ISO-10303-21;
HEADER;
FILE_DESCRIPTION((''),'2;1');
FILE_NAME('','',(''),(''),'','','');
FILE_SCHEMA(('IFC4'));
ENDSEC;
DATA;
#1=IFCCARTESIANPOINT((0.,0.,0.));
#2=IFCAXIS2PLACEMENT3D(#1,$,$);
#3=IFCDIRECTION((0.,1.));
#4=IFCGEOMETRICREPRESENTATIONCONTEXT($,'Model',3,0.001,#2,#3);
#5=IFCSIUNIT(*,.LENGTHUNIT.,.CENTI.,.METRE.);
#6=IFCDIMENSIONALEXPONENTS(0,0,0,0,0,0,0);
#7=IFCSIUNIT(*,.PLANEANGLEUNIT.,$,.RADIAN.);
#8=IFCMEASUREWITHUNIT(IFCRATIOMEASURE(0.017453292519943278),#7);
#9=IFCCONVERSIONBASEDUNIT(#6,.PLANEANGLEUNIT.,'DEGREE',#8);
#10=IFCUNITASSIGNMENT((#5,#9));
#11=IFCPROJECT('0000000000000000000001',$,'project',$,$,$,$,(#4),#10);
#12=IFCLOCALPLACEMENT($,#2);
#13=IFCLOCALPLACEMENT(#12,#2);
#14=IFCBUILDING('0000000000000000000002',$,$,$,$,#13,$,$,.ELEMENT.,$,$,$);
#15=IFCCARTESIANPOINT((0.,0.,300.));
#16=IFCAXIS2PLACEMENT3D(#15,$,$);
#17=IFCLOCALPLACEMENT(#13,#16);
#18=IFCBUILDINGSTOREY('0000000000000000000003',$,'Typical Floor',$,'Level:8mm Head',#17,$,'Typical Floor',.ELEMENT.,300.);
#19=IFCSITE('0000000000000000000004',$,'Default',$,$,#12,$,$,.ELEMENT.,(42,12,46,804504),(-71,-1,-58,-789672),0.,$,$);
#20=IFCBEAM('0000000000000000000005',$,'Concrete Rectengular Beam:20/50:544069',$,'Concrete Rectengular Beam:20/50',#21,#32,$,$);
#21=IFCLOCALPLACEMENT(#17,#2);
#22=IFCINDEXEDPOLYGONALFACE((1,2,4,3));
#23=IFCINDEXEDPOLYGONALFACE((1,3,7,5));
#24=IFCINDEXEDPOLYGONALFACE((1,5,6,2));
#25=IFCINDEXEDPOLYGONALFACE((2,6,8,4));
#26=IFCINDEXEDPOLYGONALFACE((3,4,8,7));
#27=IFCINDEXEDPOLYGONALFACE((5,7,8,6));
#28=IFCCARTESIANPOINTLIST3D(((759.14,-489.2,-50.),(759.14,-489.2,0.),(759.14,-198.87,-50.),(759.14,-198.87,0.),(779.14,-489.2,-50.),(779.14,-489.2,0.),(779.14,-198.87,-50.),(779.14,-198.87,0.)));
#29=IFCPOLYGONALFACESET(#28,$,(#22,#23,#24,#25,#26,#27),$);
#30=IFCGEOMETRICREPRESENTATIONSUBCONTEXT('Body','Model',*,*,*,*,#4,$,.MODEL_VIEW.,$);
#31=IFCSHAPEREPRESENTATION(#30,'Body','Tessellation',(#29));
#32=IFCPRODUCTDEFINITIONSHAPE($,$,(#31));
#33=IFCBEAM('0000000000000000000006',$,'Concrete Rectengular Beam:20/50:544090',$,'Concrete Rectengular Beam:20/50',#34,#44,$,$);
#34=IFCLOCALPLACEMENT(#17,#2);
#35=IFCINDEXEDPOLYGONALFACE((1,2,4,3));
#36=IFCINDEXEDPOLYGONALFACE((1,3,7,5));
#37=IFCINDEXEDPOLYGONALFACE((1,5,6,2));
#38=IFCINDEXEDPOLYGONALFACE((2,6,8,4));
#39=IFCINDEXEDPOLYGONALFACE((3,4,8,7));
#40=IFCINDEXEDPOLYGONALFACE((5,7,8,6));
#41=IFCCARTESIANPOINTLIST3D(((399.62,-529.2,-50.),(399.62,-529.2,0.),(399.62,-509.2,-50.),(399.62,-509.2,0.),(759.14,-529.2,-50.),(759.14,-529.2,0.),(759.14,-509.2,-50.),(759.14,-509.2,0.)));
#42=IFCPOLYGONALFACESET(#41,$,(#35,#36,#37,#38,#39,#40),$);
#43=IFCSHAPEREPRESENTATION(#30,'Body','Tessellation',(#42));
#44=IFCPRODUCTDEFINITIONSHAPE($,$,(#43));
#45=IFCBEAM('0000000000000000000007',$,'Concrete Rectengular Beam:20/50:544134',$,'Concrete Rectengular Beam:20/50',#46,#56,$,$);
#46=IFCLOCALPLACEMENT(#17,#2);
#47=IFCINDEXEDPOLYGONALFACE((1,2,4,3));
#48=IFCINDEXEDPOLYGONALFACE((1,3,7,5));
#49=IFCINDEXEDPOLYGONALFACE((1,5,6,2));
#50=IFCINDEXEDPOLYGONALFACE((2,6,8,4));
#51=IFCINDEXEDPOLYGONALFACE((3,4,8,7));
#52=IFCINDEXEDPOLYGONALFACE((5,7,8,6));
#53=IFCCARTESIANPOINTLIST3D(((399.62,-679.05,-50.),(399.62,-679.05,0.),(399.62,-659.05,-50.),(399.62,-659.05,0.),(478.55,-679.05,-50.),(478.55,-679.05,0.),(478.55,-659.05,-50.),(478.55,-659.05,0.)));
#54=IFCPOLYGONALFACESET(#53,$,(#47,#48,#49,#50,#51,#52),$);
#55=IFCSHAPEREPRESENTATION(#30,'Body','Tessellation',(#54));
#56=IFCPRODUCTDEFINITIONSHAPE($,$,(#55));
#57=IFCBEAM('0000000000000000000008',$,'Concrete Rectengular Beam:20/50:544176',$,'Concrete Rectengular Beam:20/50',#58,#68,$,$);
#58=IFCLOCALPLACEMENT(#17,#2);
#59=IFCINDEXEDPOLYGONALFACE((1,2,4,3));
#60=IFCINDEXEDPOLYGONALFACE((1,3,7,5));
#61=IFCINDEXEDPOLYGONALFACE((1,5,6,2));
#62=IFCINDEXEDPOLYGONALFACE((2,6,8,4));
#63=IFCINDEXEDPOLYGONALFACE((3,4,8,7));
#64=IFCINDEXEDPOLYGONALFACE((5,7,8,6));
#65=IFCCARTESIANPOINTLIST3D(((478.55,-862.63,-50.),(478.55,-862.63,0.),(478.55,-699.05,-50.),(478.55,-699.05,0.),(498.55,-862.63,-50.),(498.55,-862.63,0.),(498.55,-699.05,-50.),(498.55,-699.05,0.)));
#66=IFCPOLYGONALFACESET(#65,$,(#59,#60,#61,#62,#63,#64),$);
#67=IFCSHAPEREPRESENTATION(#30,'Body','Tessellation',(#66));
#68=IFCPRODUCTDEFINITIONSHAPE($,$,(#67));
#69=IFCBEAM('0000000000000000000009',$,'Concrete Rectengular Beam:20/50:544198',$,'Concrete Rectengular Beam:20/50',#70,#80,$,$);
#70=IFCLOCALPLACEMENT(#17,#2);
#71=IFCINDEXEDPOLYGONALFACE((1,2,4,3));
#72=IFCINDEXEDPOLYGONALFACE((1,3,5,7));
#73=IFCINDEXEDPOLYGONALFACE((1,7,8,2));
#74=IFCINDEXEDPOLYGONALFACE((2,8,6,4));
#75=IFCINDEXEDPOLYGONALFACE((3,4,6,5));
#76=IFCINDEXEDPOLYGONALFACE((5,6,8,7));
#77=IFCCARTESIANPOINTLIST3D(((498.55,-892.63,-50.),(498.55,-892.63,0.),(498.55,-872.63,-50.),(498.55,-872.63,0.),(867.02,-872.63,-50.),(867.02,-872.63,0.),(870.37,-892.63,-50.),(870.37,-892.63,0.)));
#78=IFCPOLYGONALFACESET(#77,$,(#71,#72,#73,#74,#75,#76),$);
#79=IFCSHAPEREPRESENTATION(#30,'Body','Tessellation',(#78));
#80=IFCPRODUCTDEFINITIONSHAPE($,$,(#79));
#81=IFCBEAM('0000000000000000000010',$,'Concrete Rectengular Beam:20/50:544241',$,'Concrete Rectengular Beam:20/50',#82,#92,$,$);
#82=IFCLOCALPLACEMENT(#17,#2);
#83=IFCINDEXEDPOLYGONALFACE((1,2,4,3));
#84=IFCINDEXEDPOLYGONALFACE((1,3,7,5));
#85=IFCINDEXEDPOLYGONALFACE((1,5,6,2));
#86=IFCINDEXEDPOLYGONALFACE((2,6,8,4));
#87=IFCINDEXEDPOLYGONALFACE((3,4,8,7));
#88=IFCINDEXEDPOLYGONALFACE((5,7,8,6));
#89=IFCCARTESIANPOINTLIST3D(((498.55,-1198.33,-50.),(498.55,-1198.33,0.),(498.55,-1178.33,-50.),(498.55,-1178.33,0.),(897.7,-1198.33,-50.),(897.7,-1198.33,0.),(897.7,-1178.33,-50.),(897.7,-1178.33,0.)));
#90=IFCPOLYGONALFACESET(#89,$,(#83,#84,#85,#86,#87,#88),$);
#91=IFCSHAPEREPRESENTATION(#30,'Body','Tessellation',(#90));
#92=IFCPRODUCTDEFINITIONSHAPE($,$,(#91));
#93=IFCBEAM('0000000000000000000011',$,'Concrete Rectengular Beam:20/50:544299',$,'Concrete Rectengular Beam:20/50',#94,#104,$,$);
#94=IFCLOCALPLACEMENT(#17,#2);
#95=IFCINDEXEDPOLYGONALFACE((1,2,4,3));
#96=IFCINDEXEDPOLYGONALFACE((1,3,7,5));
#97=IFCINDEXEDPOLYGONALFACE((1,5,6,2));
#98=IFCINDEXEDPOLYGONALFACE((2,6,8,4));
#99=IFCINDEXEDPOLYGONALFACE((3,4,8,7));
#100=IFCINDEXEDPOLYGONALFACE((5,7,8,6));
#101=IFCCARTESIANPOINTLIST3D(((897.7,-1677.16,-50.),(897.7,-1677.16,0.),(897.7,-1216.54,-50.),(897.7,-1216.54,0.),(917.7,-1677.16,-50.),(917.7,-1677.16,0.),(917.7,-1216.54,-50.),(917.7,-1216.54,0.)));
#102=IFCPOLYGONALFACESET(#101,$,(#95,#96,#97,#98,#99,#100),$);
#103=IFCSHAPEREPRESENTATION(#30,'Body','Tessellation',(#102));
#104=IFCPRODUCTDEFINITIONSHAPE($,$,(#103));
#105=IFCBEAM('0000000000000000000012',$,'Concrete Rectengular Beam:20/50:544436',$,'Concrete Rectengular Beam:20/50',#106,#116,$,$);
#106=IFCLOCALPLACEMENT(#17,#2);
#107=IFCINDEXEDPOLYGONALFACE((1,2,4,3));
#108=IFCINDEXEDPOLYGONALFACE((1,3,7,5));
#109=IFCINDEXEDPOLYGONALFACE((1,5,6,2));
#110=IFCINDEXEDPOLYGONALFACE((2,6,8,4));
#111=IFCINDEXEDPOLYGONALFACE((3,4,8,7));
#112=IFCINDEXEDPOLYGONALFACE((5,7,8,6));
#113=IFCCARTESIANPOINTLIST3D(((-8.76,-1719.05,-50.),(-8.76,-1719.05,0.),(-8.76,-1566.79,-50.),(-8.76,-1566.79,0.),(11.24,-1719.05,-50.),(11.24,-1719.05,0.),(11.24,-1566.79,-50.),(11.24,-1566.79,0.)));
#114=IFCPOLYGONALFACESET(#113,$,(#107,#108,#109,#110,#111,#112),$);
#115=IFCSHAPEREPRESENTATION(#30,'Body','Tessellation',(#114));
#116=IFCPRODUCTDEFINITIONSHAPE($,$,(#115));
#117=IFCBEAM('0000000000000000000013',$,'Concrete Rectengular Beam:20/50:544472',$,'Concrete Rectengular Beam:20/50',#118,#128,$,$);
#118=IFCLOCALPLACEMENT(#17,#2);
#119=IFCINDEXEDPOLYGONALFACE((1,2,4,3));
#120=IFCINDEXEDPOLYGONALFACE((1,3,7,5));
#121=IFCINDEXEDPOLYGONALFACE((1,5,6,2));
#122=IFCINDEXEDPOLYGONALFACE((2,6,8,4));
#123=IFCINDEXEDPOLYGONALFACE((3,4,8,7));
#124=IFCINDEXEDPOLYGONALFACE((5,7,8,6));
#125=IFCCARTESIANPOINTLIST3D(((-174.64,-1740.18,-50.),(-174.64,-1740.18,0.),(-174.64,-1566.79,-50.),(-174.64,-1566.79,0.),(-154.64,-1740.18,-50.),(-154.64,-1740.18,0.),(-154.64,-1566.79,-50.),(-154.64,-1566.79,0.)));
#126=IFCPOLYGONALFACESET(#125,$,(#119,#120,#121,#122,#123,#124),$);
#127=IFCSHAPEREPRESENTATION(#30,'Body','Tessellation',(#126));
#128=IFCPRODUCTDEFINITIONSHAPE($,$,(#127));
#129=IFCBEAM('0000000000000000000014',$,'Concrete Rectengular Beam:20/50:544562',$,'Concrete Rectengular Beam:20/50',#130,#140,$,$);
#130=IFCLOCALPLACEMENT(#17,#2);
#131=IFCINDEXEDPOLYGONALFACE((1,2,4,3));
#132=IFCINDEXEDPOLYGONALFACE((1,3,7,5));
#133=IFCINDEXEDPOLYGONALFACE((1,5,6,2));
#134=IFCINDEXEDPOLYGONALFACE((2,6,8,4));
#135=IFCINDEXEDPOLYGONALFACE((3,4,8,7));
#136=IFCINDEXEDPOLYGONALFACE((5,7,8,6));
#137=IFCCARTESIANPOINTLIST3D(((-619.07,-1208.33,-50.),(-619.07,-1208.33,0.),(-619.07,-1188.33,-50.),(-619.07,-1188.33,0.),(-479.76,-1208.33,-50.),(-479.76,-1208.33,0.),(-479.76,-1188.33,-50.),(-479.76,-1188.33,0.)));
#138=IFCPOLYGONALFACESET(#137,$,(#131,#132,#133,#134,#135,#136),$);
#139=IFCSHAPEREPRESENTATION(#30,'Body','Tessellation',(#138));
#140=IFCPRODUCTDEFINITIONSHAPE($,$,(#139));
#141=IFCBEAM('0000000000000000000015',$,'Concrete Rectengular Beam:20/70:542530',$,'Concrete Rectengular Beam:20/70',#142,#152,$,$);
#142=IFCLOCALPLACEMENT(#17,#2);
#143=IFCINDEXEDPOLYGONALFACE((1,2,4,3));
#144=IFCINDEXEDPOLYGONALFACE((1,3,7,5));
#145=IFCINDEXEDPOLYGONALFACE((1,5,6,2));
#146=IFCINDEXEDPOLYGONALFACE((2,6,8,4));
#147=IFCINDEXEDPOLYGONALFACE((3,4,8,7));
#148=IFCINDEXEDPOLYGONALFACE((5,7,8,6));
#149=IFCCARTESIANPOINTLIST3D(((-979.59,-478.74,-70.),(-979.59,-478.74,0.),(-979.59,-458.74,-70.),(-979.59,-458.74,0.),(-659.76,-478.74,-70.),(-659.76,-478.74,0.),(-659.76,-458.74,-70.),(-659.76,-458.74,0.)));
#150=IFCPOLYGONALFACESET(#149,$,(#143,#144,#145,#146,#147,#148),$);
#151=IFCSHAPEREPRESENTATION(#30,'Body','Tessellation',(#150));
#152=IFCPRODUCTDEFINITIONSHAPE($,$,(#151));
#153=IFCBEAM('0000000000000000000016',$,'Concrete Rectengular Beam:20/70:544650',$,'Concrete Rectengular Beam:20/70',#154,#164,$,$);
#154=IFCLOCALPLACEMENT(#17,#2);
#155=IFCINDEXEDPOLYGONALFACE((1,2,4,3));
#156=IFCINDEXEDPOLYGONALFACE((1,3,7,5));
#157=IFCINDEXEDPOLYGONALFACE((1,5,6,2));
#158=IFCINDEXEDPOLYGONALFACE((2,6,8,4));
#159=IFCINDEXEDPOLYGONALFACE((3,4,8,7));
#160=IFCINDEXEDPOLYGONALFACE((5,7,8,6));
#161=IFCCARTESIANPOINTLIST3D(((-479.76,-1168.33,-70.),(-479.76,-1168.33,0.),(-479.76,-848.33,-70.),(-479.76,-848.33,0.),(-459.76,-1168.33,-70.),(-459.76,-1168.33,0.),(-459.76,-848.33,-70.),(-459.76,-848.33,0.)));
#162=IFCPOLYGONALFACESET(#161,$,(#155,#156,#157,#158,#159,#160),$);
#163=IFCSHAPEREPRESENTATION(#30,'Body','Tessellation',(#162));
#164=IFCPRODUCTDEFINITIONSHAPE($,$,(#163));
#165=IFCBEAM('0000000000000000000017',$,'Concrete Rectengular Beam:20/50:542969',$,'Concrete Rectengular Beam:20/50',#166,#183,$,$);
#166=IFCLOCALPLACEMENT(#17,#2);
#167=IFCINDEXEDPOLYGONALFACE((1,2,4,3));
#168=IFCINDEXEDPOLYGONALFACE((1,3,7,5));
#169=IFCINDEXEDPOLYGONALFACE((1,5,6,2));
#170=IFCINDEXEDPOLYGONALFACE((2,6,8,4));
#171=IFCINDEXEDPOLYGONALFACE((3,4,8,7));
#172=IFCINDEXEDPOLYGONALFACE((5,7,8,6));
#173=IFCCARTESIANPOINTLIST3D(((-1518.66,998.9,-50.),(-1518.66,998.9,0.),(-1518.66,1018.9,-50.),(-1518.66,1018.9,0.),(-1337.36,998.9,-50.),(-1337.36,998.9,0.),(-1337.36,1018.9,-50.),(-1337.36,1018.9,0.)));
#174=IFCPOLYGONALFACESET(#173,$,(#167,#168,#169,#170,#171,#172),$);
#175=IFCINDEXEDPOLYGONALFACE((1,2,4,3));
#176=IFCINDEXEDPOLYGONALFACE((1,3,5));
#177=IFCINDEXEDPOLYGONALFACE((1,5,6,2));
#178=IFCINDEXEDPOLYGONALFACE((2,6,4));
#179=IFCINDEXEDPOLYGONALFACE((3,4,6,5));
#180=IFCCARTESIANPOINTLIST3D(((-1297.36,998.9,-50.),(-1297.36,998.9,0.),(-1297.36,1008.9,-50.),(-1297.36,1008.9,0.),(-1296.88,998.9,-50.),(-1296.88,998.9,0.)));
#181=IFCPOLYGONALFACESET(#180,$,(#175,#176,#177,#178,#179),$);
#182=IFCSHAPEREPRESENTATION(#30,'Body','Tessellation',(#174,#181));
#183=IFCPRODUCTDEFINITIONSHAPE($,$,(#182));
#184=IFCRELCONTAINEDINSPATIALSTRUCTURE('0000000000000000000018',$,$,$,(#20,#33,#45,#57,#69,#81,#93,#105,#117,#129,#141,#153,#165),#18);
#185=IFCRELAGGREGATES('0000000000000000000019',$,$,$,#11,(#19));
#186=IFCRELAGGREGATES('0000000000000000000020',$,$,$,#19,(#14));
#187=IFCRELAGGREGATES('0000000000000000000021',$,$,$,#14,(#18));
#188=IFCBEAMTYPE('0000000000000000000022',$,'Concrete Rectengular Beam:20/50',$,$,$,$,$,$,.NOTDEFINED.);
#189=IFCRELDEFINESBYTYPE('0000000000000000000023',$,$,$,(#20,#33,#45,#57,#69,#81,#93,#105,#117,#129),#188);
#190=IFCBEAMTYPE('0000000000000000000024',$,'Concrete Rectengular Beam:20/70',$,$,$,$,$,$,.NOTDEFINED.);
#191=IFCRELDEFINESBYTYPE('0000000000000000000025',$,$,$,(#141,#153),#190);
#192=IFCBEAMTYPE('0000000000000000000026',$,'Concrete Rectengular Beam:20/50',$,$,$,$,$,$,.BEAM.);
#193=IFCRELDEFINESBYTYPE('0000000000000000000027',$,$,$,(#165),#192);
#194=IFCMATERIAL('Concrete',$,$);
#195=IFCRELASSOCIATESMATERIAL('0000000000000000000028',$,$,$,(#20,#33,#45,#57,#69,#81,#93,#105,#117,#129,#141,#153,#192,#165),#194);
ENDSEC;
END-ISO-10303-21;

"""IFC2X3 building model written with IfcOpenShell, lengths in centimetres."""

from ifc_helpers import new_model, entity, si_unit, converted_unit, direction, frame, frame_2d, origin, origin_2d_with_axis, place, context, subcontext, project, spatial, rectangle, extrude, clip, halfspace, source, transform, mapped, material, type_object, type_shapes, element, save


model = new_model("IFC2X3")

# Units and contexts
model_context = context("Model", 3, precision=0.001, world=origin(), true_north=direction((0.0, 1.0)))
body_context = subcontext(model_context, "Body", "Model", "MODEL_VIEW")
ifc_project = project(units=[si_unit("LENGTHUNIT", "METRE", prefix="CENTI"), converted_unit("PLANEANGLEUNIT", "DEGREE", entity("IfcRatioMeasure", 0.017453292519943278), si_unit("PLANEANGLEUNIT", "RADIAN"), dimensions=[0, 0, 0, 0, 0, 0, 0])], contexts=[model_context])

# Site, building, storey
site_placement = place(None, origin())
site = spatial("IfcSite", under=ifc_project, at=site_placement, Name="Default", CompositionType="ELEMENT", RefLatitude=(42, 12, 46, 804504), RefLongitude=(-71, -1, -58, -789672), RefElevation=0.0)
building_placement = place(site_placement, origin())
building = spatial("IfcBuilding", under=site, at=building_placement, CompositionType="ELEMENT")
storey_placement = place(building_placement, frame((0.0, 0.0, 300.0)))
storey = spatial("IfcBuildingStorey", under=building, at=storey_placement, Name="Typical Floor", ObjectType="Level:8mm Head", LongName="Typical Floor", CompositionType="ELEMENT", Elevation=300.0)

# Beams
ifc_material = material(Name="Concrete")
beam_type_1 = type_object("IfcBeamType", Name="Concrete Rectengular Beam:20/50", PredefinedType="NOTDEFINED")
beam_1_placement = place(storey_placement, frame((769.14, -178.87, 0.0), z_axis=(0.0, 0.0, 1.0), x_axis=(0.0, -1.0, 0.0)))
element("IfcBeam", 1, at=beam_1_placement, inside=storey, type_object=beam_type_1, material=ifc_material, Name="Concrete Rectengular Beam:20/50:544069", ObjectType="Concrete Rectengular Beam:20/50", context=body_context, shape_type="SweptSolid", body=[
    extrude(rectangle(XDim=50.0, YDim=20.0, at=frame_2d((0.0, 0.0), x_axis=(1.0, 0.0))), frame((20.0, 0.0, -25.0), z_axis=(1.0, 0.0, 0.0), x_axis=(0.0, 0.0, -1.0)), (0.0, 0.0, 1.0), 290.33),
])
beam_2_placement = place(storey_placement, frame((769.14, -519.2, 0.0), z_axis=(0.0, 0.0, 1.0), x_axis=(-1.0, 0.0, 0.0)))
element("IfcBeam", 2, at=beam_2_placement, inside=storey, type_object=beam_type_1, material=ifc_material, Name="Concrete Rectengular Beam:20/50:544090", ObjectType="Concrete Rectengular Beam:20/50", context=body_context, shape_type="SweptSolid", body=[
    extrude(rectangle(XDim=50.0, YDim=20.0, at=frame_2d((0.0, 0.0), x_axis=(1.0, 0.0))), frame((10.0, 0.0, -25.0), z_axis=(1.0, 0.0, 0.0), x_axis=(0.0, 0.0, -1.0)), (0.0, 0.0, 1.0), 359.52),
])
beam_3_placement = place(storey_placement, frame((488.55, -669.05, 0.0), z_axis=(0.0, 0.0, 1.0), x_axis=(-1.0, 0.0, 0.0)))
element("IfcBeam", 3, at=beam_3_placement, inside=storey, type_object=beam_type_1, material=ifc_material, Name="Concrete Rectengular Beam:20/50:544134", ObjectType="Concrete Rectengular Beam:20/50", context=body_context, shape_type="SweptSolid", body=[
    extrude(rectangle(XDim=50.0, YDim=20.0, at=frame_2d((0.0, 0.0), x_axis=(1.0, 0.0))), frame((10.0, 0.0, -25.0), z_axis=(1.0, 0.0, 0.0), x_axis=(0.0, 0.0, -1.0)), (0.0, 0.0, 1.0), 78.94),
])
beam_4_placement = place(storey_placement, frame((488.55, -679.05, 0.0), z_axis=(0.0, 0.0, 1.0), x_axis=(0.0, -1.0, 0.0)))
element("IfcBeam", 4, at=beam_4_placement, inside=storey, type_object=beam_type_1, material=ifc_material, Name="Concrete Rectengular Beam:20/50:544176", ObjectType="Concrete Rectengular Beam:20/50", context=body_context, shape_type="SweptSolid", body=[
    extrude(rectangle(XDim=50.0, YDim=20.0, at=frame_2d((0.0, 0.0), x_axis=(1.0, 0.0))), frame((20.0, 0.0, -25.0), z_axis=(1.0, 0.0, 0.0), x_axis=(0.0, 0.0, -1.0)), (0.0, 0.0, 1.0), 163.58),
])
beam_5_placement = place(storey_placement, frame((488.55, -882.63, 0.0)))
element("IfcBeam", 5, at=beam_5_placement, inside=storey, type_object=beam_type_1, material=ifc_material, Name="Concrete Rectengular Beam:20/50:544198", ObjectType="Concrete Rectengular Beam:20/50", context=body_context, shape_type="SweptSolid", body=[
    clip(extrude(rectangle(XDim=50.0, YDim=20.0, at=frame_2d((0.0, 0.0), x_axis=(1.0, 0.0))), frame((10.0, 0.0, -25.0), z_axis=(1.0, 0.0, 0.0), x_axis=(0.0, 0.0, -1.0)), (0.0, 0.0, 1.0), 371.81), halfspace(frame((377.73, 14.38, 0.0), z_axis=(0.986305, 0.164934, 0.0), x_axis=(0.164934, -0.986305, 0.0)), False)),
])
beam_6_placement = place(storey_placement, frame((907.7, -1188.33, 0.0), z_axis=(0.0, 0.0, 1.0), x_axis=(-1.0, 0.0, 0.0)))
element("IfcBeam", 6, at=beam_6_placement, inside=storey, type_object=beam_type_1, material=ifc_material, Name="Concrete Rectengular Beam:20/50:544241", ObjectType="Concrete Rectengular Beam:20/50", context=body_context, shape_type="SweptSolid", body=[
    extrude(rectangle(XDim=50.0, YDim=20.0, at=frame_2d((0.0, 0.0), x_axis=(1.0, 0.0))), frame((10.0, 0.0, -25.0), z_axis=(1.0, 0.0, 0.0), x_axis=(0.0, 0.0, -1.0)), (0.0, 0.0, 1.0), 399.15),
])
beam_7_placement = place(storey_placement, frame((907.7, -1196.54, 0.0), z_axis=(0.0, 0.0, 1.0), x_axis=(0.0, -1.0, 0.0)))
element("IfcBeam", 7, at=beam_7_placement, inside=storey, type_object=beam_type_1, material=ifc_material, Name="Concrete Rectengular Beam:20/50:544299", ObjectType="Concrete Rectengular Beam:20/50", context=body_context, shape_type="SweptSolid", body=[
    extrude(rectangle(XDim=50.0, YDim=20.0, at=frame_2d((0.0, 0.0), x_axis=(1.0, 0.0))), frame((20.0, 0.0, -25.0), z_axis=(1.0, 0.0, 0.0), x_axis=(0.0, 0.0, -1.0)), (0.0, 0.0, 1.0), 460.62),
])
beam_8_placement = place(storey_placement, frame((1.24, -1739.05, 0.0), z_axis=(0.0, 0.0, 1.0), x_axis=(0.0, 1.0, 0.0)))
element("IfcBeam", 8, at=beam_8_placement, inside=storey, type_object=beam_type_1, material=ifc_material, Name="Concrete Rectengular Beam:20/50:544436", ObjectType="Concrete Rectengular Beam:20/50", context=body_context, shape_type="SweptSolid", body=[
    extrude(rectangle(XDim=50.0, YDim=20.0, at=origin_2d_with_axis()), frame((20.0, 0.0, -25.0), z_axis=(1.0, 0.0, 0.0), x_axis=(0.0, 0.0, -1.0)), (0.0, 0.0, 1.0), 152.25),
])
beam_9_placement = place(storey_placement, frame((-164.64, -1760.18, 0.0), z_axis=(0.0, 0.0, 1.0), x_axis=(0.0, 1.0, 0.0)))
element("IfcBeam", 9, at=beam_9_placement, inside=storey, type_object=beam_type_1, material=ifc_material, Name="Concrete Rectengular Beam:20/50:544472", ObjectType="Concrete Rectengular Beam:20/50", context=body_context, shape_type="SweptSolid", body=[
    extrude(rectangle(XDim=50.0, YDim=20.0, at=origin_2d_with_axis()), frame((20.0, 0.0, -25.0), z_axis=(1.0, 0.0, 0.0), x_axis=(0.0, 0.0, -1.0)), (0.0, 0.0, 1.0), 173.39),
])
beam_10_placement = place(storey_placement, frame((-469.76, -1198.33, 0.0), z_axis=(0.0, 0.0, 1.0), x_axis=(-1.0, 0.0, 0.0)))
element("IfcBeam", 10, at=beam_10_placement, inside=storey, type_object=beam_type_1, material=ifc_material, Name="Concrete Rectengular Beam:20/50:544562", ObjectType="Concrete Rectengular Beam:20/50", context=body_context, shape_type="SweptSolid", body=[
    extrude(rectangle(XDim=50.0, YDim=20.0, at=frame_2d((0.0, 0.0), x_axis=(1.0, 0.0))), frame((10.0, 0.0, -25.0), z_axis=(1.0, 0.0, 0.0), x_axis=(0.0, 0.0, -1.0)), (0.0, 0.0, 1.0), 139.3),
])
beam_type_2 = type_object("IfcBeamType", Name="Concrete Rectengular Beam:20/70", PredefinedType="NOTDEFINED")
beam_11_placement = place(storey_placement, frame((-999.59, -468.74, 0.0)))
element("IfcBeam", 11, at=beam_11_placement, inside=storey, type_object=beam_type_2, material=ifc_material, Name="Concrete Rectengular Beam:20/70:542530", ObjectType="Concrete Rectengular Beam:20/70", context=body_context, shape_type="SweptSolid", body=[
    extrude(rectangle(XDim=70.0, YDim=20.0, at=frame_2d((0.0, 0.0), x_axis=(1.0, 0.0))), frame((20.0, 0.0, -35.0), z_axis=(1.0, 0.0, 0.0), x_axis=(0.0, 0.0, -1.0)), (0.0, 0.0, 1.0), 319.83),
])
beam_12_placement = place(storey_placement, frame((-469.76, -1188.33, 0.0), z_axis=(0.0, 0.0, 1.0), x_axis=(0.0, 1.0, 0.0)))
element("IfcBeam", 12, at=beam_12_placement, inside=storey, type_object=beam_type_2, material=ifc_material, Name="Concrete Rectengular Beam:20/70:544650", ObjectType="Concrete Rectengular Beam:20/70", context=body_context, shape_type="SweptSolid", body=[
    extrude(rectangle(XDim=70.0, YDim=20.0, at=origin_2d_with_axis()), frame((20.0, 0.0, -35.0), z_axis=(1.0, 0.0, 0.0), x_axis=(0.0, 0.0, -1.0)), (0.0, 0.0, 1.0), 320.0),
])
beam_type_3 = type_object("IfcBeamType", Name="Concrete Rectengular Beam:20/50", PredefinedType="BEAM", material=ifc_material)
shared_shape_1 = source(origin(), body_context, "Body", "SweptSolid", [
    extrude(rectangle(XDim=50.0, YDim=20.0, at=frame_2d((0.0, 0.0), x_axis=(1.0, 0.0))), frame((-1518.66, 1008.9, 275.0), z_axis=(1.0, 0.0, 0.0), x_axis=(0.0, 0.0, -1.0)), (0.0, 0.0, 1.0), 181.3),
    clip(extrude(rectangle(XDim=50.0, YDim=10.0, at=frame_2d((0.0, 0.0), x_axis=(1.0, 0.0))), frame((-1297.36, 1003.9, 275.0), z_axis=(1.0, 0.0, 0.0), x_axis=(0.0, 0.0, -1.0)), (0.0, 0.0, 1.0), 0.48), halfspace(frame((-1297.84, 1018.9, 300.0), z_axis=(0.998865, 0.047637, 0.0), x_axis=(0.047637, -0.998865, 0.0)), False)),
])
type_shapes(beam_type_3, [shared_shape_1])
beam_13_placement = place(storey_placement, frame((0.0, 0.0, -300.0)))
element("IfcBeam", 13, at=beam_13_placement, inside=storey, type_object=beam_type_3, material=ifc_material, Name="Concrete Rectengular Beam:20/50:542969", ObjectType="Concrete Rectengular Beam:20/50", context=body_context, shape_type="MappedRepresentation", body=[
    mapped(shared_shape_1, transform((0.0, 0.0, 0.0), scale=1.0)),
])

save(model, "model.ifc")
